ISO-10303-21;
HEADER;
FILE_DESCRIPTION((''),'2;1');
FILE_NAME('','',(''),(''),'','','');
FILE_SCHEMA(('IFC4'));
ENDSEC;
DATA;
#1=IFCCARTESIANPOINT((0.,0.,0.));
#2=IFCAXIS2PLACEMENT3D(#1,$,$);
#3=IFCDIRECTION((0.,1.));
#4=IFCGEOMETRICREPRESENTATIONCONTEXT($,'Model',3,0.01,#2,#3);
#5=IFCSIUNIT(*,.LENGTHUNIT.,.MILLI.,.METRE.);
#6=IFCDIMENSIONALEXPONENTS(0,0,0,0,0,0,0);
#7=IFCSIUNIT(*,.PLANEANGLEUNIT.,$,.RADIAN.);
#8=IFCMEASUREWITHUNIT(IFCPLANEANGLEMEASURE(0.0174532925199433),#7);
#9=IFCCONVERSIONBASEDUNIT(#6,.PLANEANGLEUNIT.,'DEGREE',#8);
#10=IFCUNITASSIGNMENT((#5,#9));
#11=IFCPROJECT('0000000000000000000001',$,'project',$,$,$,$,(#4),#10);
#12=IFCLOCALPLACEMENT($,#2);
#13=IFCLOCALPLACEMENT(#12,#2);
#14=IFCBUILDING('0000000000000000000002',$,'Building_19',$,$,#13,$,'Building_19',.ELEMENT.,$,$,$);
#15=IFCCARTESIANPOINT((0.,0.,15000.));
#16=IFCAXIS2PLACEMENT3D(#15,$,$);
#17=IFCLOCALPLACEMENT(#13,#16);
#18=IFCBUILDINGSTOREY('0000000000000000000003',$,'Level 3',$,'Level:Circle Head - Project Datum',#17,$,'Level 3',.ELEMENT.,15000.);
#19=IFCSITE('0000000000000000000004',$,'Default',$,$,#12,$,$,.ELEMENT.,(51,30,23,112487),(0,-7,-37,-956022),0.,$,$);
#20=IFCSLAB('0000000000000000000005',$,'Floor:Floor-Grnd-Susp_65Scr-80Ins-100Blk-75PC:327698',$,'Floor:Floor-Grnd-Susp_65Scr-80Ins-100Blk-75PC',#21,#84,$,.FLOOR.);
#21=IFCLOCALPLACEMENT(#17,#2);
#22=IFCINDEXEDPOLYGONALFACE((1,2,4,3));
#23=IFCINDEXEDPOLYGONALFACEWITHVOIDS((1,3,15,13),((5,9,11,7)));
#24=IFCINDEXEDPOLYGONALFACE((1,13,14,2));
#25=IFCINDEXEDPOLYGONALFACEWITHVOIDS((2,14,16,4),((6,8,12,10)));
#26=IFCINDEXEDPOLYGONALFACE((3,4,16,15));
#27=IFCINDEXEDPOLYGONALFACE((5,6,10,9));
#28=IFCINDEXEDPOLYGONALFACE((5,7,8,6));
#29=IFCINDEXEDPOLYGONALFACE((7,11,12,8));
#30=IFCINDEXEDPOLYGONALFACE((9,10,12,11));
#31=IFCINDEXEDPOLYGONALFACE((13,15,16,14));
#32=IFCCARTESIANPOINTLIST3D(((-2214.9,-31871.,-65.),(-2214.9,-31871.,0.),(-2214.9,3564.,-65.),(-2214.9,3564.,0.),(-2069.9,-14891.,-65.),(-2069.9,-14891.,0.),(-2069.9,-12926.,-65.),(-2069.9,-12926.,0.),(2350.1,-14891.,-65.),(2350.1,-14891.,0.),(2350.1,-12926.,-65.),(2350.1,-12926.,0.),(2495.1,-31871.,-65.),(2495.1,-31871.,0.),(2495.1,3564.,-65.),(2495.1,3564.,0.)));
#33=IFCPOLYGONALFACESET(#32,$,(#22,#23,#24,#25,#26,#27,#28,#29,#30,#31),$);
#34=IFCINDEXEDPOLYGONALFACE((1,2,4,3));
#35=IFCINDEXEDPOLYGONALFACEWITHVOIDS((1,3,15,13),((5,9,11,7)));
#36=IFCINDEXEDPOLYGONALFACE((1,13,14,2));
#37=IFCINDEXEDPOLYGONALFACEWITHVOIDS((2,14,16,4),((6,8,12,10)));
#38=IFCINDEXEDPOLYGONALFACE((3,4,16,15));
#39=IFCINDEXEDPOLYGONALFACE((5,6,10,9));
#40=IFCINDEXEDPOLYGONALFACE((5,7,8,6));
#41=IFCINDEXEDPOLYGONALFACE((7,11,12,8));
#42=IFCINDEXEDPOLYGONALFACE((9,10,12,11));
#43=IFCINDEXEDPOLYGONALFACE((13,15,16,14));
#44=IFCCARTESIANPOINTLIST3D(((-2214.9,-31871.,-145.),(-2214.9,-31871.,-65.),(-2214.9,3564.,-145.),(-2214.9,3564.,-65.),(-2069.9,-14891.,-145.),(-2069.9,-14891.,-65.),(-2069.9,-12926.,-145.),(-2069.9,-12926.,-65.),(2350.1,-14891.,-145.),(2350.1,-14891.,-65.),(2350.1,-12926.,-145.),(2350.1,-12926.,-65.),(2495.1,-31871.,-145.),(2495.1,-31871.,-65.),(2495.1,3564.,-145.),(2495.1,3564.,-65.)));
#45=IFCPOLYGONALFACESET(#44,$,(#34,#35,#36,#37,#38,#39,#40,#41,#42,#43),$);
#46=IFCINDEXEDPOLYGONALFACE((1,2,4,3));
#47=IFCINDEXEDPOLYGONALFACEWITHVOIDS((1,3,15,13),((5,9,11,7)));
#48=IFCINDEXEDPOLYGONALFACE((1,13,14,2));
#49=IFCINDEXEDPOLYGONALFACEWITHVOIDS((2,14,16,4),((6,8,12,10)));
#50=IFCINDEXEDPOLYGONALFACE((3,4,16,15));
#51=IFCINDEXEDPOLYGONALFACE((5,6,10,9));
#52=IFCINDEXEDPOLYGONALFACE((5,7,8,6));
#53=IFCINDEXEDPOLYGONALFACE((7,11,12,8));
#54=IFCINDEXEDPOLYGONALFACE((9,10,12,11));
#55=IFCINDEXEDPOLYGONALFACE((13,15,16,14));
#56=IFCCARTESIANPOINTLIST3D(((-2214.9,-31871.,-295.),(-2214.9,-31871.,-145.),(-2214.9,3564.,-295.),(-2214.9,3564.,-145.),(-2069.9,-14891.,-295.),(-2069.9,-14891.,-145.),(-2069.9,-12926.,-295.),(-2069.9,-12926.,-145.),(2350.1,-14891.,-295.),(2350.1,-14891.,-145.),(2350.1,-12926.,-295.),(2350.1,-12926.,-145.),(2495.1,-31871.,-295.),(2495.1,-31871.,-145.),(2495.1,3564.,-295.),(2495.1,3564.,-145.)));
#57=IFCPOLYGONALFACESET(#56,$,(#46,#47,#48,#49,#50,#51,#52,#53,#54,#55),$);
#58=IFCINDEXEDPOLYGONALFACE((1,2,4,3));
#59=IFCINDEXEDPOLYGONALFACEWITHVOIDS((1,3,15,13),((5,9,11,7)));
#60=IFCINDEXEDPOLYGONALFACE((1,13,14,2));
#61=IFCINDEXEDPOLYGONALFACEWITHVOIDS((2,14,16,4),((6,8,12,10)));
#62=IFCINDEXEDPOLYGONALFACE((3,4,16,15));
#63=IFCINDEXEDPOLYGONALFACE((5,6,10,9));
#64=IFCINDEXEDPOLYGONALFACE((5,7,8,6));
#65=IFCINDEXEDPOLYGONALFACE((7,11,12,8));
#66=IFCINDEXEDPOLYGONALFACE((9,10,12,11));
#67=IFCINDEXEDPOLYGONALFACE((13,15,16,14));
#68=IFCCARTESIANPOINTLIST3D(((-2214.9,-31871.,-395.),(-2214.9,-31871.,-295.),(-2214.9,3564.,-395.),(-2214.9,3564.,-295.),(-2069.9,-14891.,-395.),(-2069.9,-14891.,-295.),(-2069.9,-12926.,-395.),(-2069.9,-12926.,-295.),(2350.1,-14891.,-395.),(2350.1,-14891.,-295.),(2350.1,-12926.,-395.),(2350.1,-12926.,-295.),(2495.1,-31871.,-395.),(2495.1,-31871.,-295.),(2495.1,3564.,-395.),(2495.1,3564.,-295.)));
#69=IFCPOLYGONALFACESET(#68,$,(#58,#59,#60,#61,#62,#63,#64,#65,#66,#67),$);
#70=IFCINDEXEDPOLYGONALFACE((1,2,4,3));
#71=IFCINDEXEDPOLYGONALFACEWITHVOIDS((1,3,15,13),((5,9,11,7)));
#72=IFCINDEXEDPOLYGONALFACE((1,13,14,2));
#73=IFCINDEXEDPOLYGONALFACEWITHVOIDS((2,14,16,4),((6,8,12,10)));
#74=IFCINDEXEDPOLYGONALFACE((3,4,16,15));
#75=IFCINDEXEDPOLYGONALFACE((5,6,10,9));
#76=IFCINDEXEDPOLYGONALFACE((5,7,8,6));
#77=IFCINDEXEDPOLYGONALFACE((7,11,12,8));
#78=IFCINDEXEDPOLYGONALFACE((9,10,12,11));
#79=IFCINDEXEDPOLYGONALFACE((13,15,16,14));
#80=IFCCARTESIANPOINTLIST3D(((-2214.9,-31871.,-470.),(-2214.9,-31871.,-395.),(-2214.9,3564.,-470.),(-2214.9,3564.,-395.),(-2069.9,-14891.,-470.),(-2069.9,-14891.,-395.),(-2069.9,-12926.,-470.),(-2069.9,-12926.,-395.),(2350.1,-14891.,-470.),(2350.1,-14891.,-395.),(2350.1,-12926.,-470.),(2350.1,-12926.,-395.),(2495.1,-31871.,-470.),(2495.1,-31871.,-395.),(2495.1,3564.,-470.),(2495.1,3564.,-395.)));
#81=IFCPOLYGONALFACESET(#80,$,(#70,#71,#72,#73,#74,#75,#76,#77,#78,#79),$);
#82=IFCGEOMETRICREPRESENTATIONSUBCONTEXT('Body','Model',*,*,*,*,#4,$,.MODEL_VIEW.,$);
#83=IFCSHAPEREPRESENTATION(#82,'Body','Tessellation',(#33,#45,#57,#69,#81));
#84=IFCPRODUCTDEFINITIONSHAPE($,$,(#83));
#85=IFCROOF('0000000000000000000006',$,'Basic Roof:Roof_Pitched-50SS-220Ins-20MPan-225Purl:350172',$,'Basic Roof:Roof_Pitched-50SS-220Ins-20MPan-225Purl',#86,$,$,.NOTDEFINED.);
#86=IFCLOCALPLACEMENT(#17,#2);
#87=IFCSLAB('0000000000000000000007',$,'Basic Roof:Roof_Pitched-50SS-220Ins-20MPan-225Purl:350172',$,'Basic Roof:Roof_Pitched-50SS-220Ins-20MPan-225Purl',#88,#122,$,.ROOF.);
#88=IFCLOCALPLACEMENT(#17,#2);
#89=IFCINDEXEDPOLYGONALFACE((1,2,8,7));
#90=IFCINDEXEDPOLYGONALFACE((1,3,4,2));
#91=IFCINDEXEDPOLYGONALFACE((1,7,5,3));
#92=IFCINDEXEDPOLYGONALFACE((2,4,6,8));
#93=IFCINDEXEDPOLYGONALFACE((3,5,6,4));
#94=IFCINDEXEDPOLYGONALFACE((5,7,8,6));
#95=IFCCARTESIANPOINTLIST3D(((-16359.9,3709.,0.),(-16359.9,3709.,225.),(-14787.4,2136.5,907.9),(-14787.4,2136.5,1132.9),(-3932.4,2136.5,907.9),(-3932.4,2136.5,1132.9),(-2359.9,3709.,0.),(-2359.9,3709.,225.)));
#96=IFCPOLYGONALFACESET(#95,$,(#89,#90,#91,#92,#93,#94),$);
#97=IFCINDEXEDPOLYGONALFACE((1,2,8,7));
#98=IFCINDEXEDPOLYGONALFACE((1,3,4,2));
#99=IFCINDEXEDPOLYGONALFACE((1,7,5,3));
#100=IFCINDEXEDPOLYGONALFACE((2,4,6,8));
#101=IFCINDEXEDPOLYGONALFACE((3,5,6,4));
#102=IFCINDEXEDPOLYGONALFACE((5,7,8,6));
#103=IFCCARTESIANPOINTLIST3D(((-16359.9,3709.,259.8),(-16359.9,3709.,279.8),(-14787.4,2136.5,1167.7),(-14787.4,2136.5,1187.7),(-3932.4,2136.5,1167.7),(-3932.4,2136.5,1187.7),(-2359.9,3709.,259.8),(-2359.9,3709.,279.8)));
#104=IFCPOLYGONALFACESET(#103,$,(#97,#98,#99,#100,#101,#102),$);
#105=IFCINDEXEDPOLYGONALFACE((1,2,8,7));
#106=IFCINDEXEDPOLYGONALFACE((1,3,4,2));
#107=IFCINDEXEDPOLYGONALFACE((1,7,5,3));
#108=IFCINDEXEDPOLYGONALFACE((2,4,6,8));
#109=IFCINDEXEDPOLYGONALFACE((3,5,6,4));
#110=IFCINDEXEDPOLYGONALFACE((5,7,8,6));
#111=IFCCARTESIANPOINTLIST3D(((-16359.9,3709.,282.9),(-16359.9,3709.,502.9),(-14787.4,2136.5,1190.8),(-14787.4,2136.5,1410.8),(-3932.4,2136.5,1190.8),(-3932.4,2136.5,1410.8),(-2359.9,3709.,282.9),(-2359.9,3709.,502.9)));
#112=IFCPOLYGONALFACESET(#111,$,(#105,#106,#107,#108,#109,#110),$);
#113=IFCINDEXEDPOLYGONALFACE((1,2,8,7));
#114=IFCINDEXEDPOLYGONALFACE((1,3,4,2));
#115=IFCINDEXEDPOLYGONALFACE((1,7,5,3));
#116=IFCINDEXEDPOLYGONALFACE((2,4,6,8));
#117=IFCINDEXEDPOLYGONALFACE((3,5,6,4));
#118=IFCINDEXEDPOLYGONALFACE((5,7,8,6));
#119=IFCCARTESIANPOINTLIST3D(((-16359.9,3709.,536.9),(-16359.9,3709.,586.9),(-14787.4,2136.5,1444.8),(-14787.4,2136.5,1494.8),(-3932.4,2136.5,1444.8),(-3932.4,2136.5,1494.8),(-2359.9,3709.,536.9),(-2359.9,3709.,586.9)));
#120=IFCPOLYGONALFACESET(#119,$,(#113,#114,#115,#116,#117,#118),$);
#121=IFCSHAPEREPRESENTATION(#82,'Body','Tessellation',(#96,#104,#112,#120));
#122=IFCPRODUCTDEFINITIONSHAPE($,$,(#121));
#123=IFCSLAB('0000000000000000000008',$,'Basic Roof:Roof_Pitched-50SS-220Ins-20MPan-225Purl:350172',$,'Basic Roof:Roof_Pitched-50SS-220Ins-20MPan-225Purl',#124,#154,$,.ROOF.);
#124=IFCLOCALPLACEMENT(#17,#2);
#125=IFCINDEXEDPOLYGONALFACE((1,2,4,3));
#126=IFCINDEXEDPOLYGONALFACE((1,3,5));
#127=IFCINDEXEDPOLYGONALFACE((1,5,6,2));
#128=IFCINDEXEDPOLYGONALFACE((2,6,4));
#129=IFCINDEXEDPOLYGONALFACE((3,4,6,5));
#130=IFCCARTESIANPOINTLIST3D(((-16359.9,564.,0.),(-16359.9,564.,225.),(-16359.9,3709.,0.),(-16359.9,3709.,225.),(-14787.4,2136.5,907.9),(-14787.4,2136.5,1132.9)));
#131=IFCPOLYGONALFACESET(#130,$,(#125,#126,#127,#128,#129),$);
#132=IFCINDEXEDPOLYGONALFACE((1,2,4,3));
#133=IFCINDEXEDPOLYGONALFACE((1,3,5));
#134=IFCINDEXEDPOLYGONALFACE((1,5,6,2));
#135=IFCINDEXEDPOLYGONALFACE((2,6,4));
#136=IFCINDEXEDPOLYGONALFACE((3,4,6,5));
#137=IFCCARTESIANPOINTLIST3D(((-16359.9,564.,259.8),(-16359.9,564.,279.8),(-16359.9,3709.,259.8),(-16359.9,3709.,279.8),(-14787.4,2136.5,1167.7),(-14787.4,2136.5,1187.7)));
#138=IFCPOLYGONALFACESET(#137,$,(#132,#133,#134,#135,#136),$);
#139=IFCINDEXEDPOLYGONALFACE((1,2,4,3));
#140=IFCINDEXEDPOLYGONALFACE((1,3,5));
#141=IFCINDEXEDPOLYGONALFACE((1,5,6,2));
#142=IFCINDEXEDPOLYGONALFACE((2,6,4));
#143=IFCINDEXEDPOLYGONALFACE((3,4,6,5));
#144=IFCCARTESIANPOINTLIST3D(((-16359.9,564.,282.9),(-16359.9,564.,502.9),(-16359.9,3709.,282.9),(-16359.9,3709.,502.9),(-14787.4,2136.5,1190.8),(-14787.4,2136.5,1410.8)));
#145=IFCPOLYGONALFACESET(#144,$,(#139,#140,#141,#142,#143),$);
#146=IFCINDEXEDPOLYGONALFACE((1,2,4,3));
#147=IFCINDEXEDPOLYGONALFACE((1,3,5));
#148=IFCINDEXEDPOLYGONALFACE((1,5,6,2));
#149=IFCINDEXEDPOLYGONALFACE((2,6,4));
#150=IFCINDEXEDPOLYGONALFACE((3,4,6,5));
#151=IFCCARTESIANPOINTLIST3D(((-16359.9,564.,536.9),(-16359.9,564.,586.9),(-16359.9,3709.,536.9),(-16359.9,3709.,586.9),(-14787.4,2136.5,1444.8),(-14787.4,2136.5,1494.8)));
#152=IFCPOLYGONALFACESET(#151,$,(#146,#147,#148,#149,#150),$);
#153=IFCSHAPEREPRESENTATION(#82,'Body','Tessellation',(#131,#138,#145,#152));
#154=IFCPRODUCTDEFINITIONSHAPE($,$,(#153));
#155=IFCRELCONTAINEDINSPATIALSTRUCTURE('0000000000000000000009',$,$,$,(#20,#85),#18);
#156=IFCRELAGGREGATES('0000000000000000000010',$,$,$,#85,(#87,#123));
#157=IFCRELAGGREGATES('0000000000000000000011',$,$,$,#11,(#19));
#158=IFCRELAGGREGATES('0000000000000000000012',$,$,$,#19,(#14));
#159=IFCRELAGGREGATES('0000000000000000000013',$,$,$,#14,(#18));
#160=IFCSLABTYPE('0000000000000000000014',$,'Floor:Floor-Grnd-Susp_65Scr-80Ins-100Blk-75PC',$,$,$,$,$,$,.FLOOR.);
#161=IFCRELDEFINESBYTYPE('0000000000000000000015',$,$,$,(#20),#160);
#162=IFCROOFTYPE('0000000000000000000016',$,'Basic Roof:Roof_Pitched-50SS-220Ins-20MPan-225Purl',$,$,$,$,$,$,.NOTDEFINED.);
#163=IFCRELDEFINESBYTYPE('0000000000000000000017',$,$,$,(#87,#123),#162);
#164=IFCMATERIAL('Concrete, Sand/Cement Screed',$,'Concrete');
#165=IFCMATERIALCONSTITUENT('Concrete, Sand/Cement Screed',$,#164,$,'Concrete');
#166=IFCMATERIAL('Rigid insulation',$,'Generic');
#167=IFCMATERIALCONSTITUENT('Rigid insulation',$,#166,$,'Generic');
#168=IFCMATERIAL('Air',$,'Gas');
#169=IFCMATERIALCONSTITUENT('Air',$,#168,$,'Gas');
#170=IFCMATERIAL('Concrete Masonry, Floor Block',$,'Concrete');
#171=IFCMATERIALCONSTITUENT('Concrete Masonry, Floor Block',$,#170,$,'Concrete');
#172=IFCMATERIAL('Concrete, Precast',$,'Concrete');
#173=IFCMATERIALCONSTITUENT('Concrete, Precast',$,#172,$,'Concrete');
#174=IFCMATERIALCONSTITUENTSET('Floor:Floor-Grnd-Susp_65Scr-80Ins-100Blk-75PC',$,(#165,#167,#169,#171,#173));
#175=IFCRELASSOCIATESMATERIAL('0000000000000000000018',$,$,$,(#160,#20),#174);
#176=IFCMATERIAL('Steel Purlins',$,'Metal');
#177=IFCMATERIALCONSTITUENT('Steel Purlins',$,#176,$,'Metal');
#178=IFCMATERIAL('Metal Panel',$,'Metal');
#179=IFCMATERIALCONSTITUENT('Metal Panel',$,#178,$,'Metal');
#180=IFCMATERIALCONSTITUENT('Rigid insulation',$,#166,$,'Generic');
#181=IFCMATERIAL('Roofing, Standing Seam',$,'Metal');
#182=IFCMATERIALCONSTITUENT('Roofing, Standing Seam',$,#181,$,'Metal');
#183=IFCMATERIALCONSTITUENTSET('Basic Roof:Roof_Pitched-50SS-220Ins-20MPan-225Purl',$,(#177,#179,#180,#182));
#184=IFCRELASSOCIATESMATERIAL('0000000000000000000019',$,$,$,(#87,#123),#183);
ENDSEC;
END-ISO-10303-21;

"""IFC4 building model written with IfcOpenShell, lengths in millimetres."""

from ifc_helpers import new_model, entity, si_unit, converted_unit, direction, frame, origin, place, context, subcontext, project, spatial, indexed_curve, outline, extrude, material, constituent, constituent_set, type_object, element, aggregate, save


model = new_model("IFC4")

# Units and contexts
model_context = context("Model", 3, precision=0.01, world=origin(), true_north=direction((0.0, 1.0)))
body_context = subcontext(model_context, "Body", "Model", "MODEL_VIEW")
ifc_project = project(units=[si_unit("LENGTHUNIT", "METRE", prefix="MILLI"), converted_unit("PLANEANGLEUNIT", "DEGREE", entity("IfcPlaneAngleMeasure", 0.0174532925199433), si_unit("PLANEANGLEUNIT", "RADIAN"), dimensions=[0, 0, 0, 0, 0, 0, 0])], contexts=[model_context])

# Site, building, storey
site_placement = place(None, origin())
site = spatial("IfcSite", under=ifc_project, at=site_placement, Name="Default", CompositionType="ELEMENT", RefLatitude=(51, 30, 23, 112487), RefLongitude=(0, -7, -37, -956022), RefElevation=0.0)
building_placement = place(site_placement, origin())
building = spatial("IfcBuilding", under=site, at=building_placement, Name="Building_19", LongName="Building_19", CompositionType="ELEMENT")
storey_placement = place(building_placement, frame((0.0, 0.0, 15000.0)))
storey = spatial("IfcBuildingStorey", under=building, at=storey_placement, Name="Level 3", ObjectType="Level:Circle Head - Project Datum", LongName="Level 3", CompositionType="ELEMENT", Elevation=15000.0)

# Slab, opening
ifc_material_1 = material(Name="Concrete, Sand/Cement Screed", Category="Concrete")
ifc_constituent_1 = constituent(ifc_material_1, Name="Concrete, Sand/Cement Screed", Category="Concrete")
ifc_material_2 = material(Name="Rigid insulation", Category="Generic")
ifc_constituent_2 = constituent(ifc_material_2, Name="Rigid insulation", Category="Generic")
ifc_material_3 = material(Name="Air", Category="Gas")
ifc_constituent_3 = constituent(ifc_material_3, Name="Air", Category="Gas")
ifc_material_4 = material(Name="Concrete Masonry, Floor Block", Category="Concrete")
ifc_constituent_4 = constituent(ifc_material_4, Name="Concrete Masonry, Floor Block", Category="Concrete")
ifc_material_5 = material(Name="Concrete, Precast", Category="Concrete")
ifc_constituent_5 = constituent(ifc_material_5, Name="Concrete, Precast", Category="Concrete")
ifc_constituent_set_1 = constituent_set(constituents=[ifc_constituent_1, ifc_constituent_2, ifc_constituent_3, ifc_constituent_4, ifc_constituent_5], Name="Floor:Floor-Grnd-Susp_65Scr-80Ins-100Blk-75PC")
slab_type = type_object("IfcSlabType", Name="Floor:Floor-Grnd-Susp_65Scr-80Ins-100Blk-75PC", PredefinedType="FLOOR", material=ifc_constituent_set_1)
slab_1_placement = place(storey_placement, origin())
slab_1 = element("IfcSlab", 1, at=slab_1_placement, inside=storey, type_object=slab_type, material=ifc_constituent_set_1, Name="Floor:Floor-Grnd-Susp_65Scr-80Ins-100Blk-75PC:327698", ObjectType="Floor:Floor-Grnd-Susp_65Scr-80Ins-100Blk-75PC", PredefinedType="FLOOR", context=body_context, shape_type="SweptSolid", body=[
    extrude(outline(indexed_curve([(-2355.0, -17717.5), (2355.0, -17717.5), (2355.0, 17717.5), (-2355.0, 17717.5), (-2355.0, -17717.5)], self_intersect=False), holes=[indexed_curve([(-2210.0, 737.5), (2210.0, 737.5), (2210.0, -1227.5), (-2210.0, -1227.5), (-2210.0, 737.5)], self_intersect=False)]), frame((140.1, -14153.5, -65.0), z_axis=(0.0, 0.0, 1.0), x_axis=(-1.0, 0.0, 0.0)), (0.0, 0.0, 1.0), 65.0),
    extrude(outline(indexed_curve([(-2355.0, -17717.5), (2355.0, -17717.5), (2355.0, 17717.5), (-2355.0, 17717.5), (-2355.0, -17717.5)], self_intersect=False), holes=[indexed_curve([(-2210.0, 737.5), (2210.0, 737.5), (2210.0, -1227.5), (-2210.0, -1227.5), (-2210.0, 737.5)], self_intersect=False)]), frame((140.1, -14153.5, -145.0), z_axis=(0.0, 0.0, 1.0), x_axis=(-1.0, 0.0, 0.0)), (0.0, 0.0, 1.0), 80.0),
    extrude(outline(indexed_curve([(-2355.0, -17717.5), (2355.0, -17717.5), (2355.0, 17717.5), (-2355.0, 17717.5), (-2355.0, -17717.5)], self_intersect=False), holes=[indexed_curve([(-2210.0, 737.5), (2210.0, 737.5), (2210.0, -1227.5), (-2210.0, -1227.5), (-2210.0, 737.5)], self_intersect=False)]), frame((140.1, -14153.5, -295.0), z_axis=(0.0, 0.0, 1.0), x_axis=(-1.0, 0.0, 0.0)), (0.0, 0.0, 1.0), 150.0),
    extrude(outline(indexed_curve([(-2355.0, -17717.5), (2355.0, -17717.5), (2355.0, 17717.5), (-2355.0, 17717.5), (-2355.0, -17717.5)], self_intersect=False), holes=[indexed_curve([(-2210.0, 737.5), (2210.0, 737.5), (2210.0, -1227.5), (-2210.0, -1227.5), (-2210.0, 737.5)], self_intersect=False)]), frame((140.1, -14153.5, -395.0), z_axis=(0.0, 0.0, 1.0), x_axis=(-1.0, 0.0, 0.0)), (0.0, 0.0, 1.0), 100.0),
    extrude(outline(indexed_curve([(-2355.0, -17717.5), (2355.0, -17717.5), (2355.0, 17717.5), (-2355.0, 17717.5), (-2355.0, -17717.5)], self_intersect=False), holes=[indexed_curve([(-2210.0, 737.5), (2210.0, 737.5), (2210.0, -1227.5), (-2210.0, -1227.5), (-2210.0, 737.5)], self_intersect=False)]), frame((140.1, -14153.5, -470.0), z_axis=(0.0, 0.0, 1.0), x_axis=(-1.0, 0.0, 0.0)), (0.0, 0.0, 1.0), 75.0),
])
opening_1_placement = place(slab_1_placement, origin())
element("IfcOpeningElement", 2, at=opening_1_placement, cuts=slab_1, PredefinedType="OPENING", context=body_context, shape_type="SweptSolid", body=[
    extrude(outline(indexed_curve([(-982.5, -2210.0), (982.5, -2210.0), (982.5, 2210.0), (-982.5, 2210.0), (-982.5, -2210.0)], self_intersect=False)), frame((140.1, -13908.5, -470.0), z_axis=(0.0, 0.0, 1.0), x_axis=(0.0, 1.0, 0.0)), (0.0, 0.0, 1.0), 470.0),
])

# Roof, slabs
roof_1_placement = place(storey_placement, frame((-16359.9, 564.0, 0.0)))
roof_1 = element("IfcRoof", 3, at=roof_1_placement, inside=storey, Name="Basic Roof:Roof_Pitched-50SS-220Ins-20MPan-225Purl:350172", ObjectType="Basic Roof:Roof_Pitched-50SS-220Ins-20MPan-225Purl", PredefinedType="NOTDEFINED")
ifc_material_6 = material(Name="Steel Purlins", Category="Metal")
ifc_constituent_6 = constituent(ifc_material_6, Name="Steel Purlins", Category="Metal")
ifc_material_7 = material(Name="Metal Panel", Category="Metal")
ifc_constituent_7 = constituent(ifc_material_7, Name="Metal Panel", Category="Metal")
ifc_constituent_8 = constituent(ifc_material_2, Name="Rigid insulation", Category="Generic")
ifc_material_8 = material(Name="Roofing, Standing Seam", Category="Metal")
ifc_constituent_9 = constituent(ifc_material_8, Name="Roofing, Standing Seam", Category="Metal")
ifc_constituent_set_2 = constituent_set(constituents=[ifc_constituent_6, ifc_constituent_7, ifc_constituent_8, ifc_constituent_9], Name="Basic Roof:Roof_Pitched-50SS-220Ins-20MPan-225Purl")
roof_type = type_object("IfcRoofType", Name="Basic Roof:Roof_Pitched-50SS-220Ins-20MPan-225Purl", PredefinedType="NOTDEFINED")
slab_2_placement = place(roof_1_placement, origin())
slab_2 = element("IfcSlab", 4, at=slab_2_placement, type_object=roof_type, material=ifc_constituent_set_2, Name="Basic Roof:Roof_Pitched-50SS-220Ins-20MPan-225Purl:350172", ObjectType="Basic Roof:Roof_Pitched-50SS-220Ins-20MPan-225Purl", PredefinedType="ROOF", context=body_context, shape_type="SweptSolid", body=[
    extrude(outline(indexed_curve([(7000.0, 907.9), (-7000.0, 907.9), (-5427.5, -907.9), (5427.5, -907.9), (7000.0, 907.9)], self_intersect=False)), frame((7000.0, 2358.8, 453.9), z_axis=(0.0, 0.5, 0.866025), x_axis=(1.0, 0.0, 0.0)), (0.0, -0.5, 0.866025), 225.0),
    extrude(outline(indexed_curve([(7000.0, 907.9), (-7000.0, 907.9), (-5427.5, -907.9), (5427.5, -907.9), (7000.0, 907.9)], self_intersect=False)), frame((7000.0, 2358.8, 713.7), z_axis=(0.0, 0.5, 0.866025), x_axis=(1.0, 0.0, 0.0)), (0.0, -0.5, 0.866025), 20.0),
    extrude(outline(indexed_curve([(7000.0, 907.9), (-7000.0, 907.9), (-5427.5, -907.9), (5427.5, -907.9), (7000.0, 907.9)], self_intersect=False)), frame((7000.0, 2358.8, 736.8), z_axis=(0.0, 0.5, 0.866025), x_axis=(1.0, 0.0, 0.0)), (0.0, -0.5, 0.866025), 220.0),
    extrude(outline(indexed_curve([(7000.0, 907.9), (-7000.0, 907.9), (-5427.5, -907.9), (5427.5, -907.9), (7000.0, 907.9)], self_intersect=False)), frame((7000.0, 2358.8, 990.9), z_axis=(0.0, 0.5, 0.866025), x_axis=(1.0, 0.0, 0.0)), (0.0, -0.5, 0.866025), 50.0),
])
slab_3_placement = place(roof_1_placement, origin())
slab_3 = element("IfcSlab", 5, at=slab_3_placement, type_object=roof_type, material=ifc_constituent_set_2, Name="Basic Roof:Roof_Pitched-50SS-220Ins-20MPan-225Purl:350172", ObjectType="Basic Roof:Roof_Pitched-50SS-220Ins-20MPan-225Purl", PredefinedType="ROOF", context=body_context, shape_type="SweptSolid", body=[
    extrude(outline(indexed_curve([(-907.9, 1572.5), (-907.9, -1572.5), (907.9, 0.0), (-907.9, 1572.5)], self_intersect=False)), frame((786.3, 1572.5, 453.9), z_axis=(-0.5, 0.0, 0.866025), x_axis=(0.866025, 0.0, 0.5)), (0.5, 0.0, 0.866025), 225.0),
    extrude(outline(indexed_curve([(-907.9, 1572.5), (-907.9, -1572.5), (907.9, 0.0), (-907.9, 1572.5)], self_intersect=False)), frame((786.3, 1572.5, 713.7), z_axis=(-0.5, 0.0, 0.866025), x_axis=(0.866025, 0.0, 0.5)), (0.5, 0.0, 0.866025), 20.0),
    extrude(outline(indexed_curve([(-907.9, 1572.5), (-907.9, -1572.5), (907.9, 0.0), (-907.9, 1572.5)], self_intersect=False)), frame((786.3, 1572.5, 736.8), z_axis=(-0.5, 0.0, 0.866025), x_axis=(0.866025, 0.0, 0.5)), (0.5, 0.0, 0.866025), 220.0),
    extrude(outline(indexed_curve([(-907.9, 1572.5), (-907.9, -1572.5), (907.9, 0.0), (-907.9, 1572.5)], self_intersect=False)), frame((786.3, 1572.5, 990.9), z_axis=(-0.5, 0.0, 0.866025), x_axis=(0.866025, 0.0, 0.5)), (0.5, 0.0, 0.866025), 50.0),
])
aggregate(roof_1, [slab_2, slab_3])

save(model, "model.ifc")
